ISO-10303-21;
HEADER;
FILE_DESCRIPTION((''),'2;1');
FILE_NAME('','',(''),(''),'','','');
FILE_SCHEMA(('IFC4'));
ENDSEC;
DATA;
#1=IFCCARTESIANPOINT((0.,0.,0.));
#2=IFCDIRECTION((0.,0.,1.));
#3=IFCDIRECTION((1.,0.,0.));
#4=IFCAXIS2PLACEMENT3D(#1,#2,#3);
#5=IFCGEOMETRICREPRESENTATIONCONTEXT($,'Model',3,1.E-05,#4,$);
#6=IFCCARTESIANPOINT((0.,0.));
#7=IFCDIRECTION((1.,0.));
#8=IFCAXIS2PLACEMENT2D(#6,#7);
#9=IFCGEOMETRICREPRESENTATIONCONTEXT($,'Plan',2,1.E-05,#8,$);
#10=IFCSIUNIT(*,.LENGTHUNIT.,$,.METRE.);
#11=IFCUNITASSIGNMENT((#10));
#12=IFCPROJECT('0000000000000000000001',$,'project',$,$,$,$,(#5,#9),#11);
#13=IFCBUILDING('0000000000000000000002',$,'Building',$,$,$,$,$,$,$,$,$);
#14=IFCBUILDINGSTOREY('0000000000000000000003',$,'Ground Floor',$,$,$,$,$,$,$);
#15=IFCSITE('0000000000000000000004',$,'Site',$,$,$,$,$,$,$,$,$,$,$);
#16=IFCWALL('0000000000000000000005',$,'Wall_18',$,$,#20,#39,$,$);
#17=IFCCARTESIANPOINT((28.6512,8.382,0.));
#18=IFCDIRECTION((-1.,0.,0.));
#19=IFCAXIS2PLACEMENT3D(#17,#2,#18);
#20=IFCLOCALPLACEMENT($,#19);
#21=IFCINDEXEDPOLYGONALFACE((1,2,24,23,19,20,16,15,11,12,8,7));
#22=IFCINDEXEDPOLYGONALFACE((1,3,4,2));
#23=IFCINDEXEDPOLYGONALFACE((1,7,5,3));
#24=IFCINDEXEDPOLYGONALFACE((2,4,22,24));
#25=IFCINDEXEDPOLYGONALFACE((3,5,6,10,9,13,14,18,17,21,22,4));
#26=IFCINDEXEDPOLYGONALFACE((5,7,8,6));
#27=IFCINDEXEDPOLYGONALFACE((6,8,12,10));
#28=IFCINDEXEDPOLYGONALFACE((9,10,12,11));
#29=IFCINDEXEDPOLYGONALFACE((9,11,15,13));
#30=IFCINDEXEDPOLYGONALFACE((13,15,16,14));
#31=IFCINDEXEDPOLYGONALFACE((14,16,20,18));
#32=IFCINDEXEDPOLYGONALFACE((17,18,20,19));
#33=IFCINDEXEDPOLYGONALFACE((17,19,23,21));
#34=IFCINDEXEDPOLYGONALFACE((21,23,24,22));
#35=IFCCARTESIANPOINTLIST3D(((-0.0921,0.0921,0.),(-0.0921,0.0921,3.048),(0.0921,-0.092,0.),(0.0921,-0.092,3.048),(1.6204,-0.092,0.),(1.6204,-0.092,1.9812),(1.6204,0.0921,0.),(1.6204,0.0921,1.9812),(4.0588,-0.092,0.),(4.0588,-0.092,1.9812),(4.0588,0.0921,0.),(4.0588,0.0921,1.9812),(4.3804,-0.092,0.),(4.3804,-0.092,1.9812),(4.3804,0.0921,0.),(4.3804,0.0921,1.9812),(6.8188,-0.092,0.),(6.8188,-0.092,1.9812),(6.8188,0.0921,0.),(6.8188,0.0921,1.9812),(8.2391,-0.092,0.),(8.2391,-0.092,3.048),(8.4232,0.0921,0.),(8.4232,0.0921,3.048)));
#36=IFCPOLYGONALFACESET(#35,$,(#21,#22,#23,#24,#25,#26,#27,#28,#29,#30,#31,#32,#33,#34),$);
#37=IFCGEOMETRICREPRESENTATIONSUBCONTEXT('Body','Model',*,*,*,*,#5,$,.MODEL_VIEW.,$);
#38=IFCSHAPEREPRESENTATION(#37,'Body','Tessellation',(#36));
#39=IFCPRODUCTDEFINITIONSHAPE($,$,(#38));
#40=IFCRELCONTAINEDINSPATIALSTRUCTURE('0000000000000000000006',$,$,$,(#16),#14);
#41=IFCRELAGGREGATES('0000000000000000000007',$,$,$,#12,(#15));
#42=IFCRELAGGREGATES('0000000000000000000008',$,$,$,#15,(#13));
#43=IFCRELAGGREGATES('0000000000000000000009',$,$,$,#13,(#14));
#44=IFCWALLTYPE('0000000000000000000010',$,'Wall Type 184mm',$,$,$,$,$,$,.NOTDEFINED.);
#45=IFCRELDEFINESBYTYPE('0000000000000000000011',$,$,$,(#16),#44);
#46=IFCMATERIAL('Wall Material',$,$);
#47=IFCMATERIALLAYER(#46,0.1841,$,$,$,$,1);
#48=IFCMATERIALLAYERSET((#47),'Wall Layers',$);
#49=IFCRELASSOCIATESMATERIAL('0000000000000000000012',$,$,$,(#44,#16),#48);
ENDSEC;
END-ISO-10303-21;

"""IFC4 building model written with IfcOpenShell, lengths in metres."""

from ifc_helpers import new_model, si_unit, frame, origin_with_axes, origin_2d_with_axis, place, context, subcontext, project, spatial, line, indexed_curve, rectangle, outline, extrude, material, layer, layer_set, layer_usage, type_object, element, save


model = new_model("IFC4")

# Units and contexts
model_context = context("Model", 3, precision=1e-05, world=origin_with_axes())
plan_context = context("Plan", 2, precision=1e-05, world=origin_2d_with_axis())
body_context = subcontext(model_context, "Body", "Model", "MODEL_VIEW")
ifc_project = project(units=[si_unit("LENGTHUNIT", "METRE")], contexts=[model_context, plan_context])

# Site, building, storey
site = spatial("IfcSite", under=ifc_project, Name="Site")
building = spatial("IfcBuilding", under=site, Name="Building")
storey = spatial("IfcBuildingStorey", under=building, Name="Ground Floor")

# Shared definitions
ifc_material_1 = material(Name="Wall Material")
ifc_layer_1 = layer(ifc_material_1, 0.1841, Priority=1)
ifc_layer_set_1 = layer_set([ifc_layer_1], Name="Wall Layers")
wall_type_1 = type_object("IfcWallType", Name="Wall Type 184mm", PredefinedType="NOTDEFINED", material=ifc_layer_set_1)

# Wall, openings
ifc_layer_usage_1 = layer_usage(ifc_layer_set_1, "AXIS2", "POSITIVE", -0.0921)
wall_1_placement = place(None, frame((28.6512, 8.382, 0.0), z_axis=(0.0, 0.0, 1.0), x_axis=(-1.0, 0.0, 0.0)))
wall_1 = element("IfcWall", 1, at=wall_1_placement, inside=storey, type_object=wall_type_1, material=ifc_layer_usage_1, Name="Wall_18", context=body_context, shape_type="SweptSolid", body=[
    extrude(outline(indexed_curve([(0.0921, -0.0921), (-0.0921, 0.0921), (8.4233, 0.0921), (8.2392, -0.0921)], segments=[line(1, 2, 3, 4, 1)])), origin_with_axes(), (0.0, 0.0, 1.0), 3.048),
])
opening_1_placement = place(wall_1_placement, frame((5.5996, 0.0, -0.4572), z_axis=(0.0, 0.0, 1.0), x_axis=(1.0, 0.0, 0.0)))
element("IfcOpeningElement", 2, at=opening_1_placement, cuts=wall_1, context=body_context, shape_type="SweptSolid", body=[
    extrude(rectangle(XDim=2.4384, YDim=0.5524), None, (0.0, 0.0, 1.0), 2.4384),
])
opening_2_placement = place(wall_1_placement, frame((2.8396, 0.0, -0.4572), z_axis=(0.0, 0.0, 1.0), x_axis=(1.0, 0.0, 0.0)))
element("IfcOpeningElement", 3, at=opening_2_placement, cuts=wall_1, context=body_context, shape_type="SweptSolid", body=[
    extrude(rectangle(XDim=2.4384, YDim=0.5524), None, (0.0, 0.0, 1.0), 2.4384),
])

save(model, "model.ifc")
